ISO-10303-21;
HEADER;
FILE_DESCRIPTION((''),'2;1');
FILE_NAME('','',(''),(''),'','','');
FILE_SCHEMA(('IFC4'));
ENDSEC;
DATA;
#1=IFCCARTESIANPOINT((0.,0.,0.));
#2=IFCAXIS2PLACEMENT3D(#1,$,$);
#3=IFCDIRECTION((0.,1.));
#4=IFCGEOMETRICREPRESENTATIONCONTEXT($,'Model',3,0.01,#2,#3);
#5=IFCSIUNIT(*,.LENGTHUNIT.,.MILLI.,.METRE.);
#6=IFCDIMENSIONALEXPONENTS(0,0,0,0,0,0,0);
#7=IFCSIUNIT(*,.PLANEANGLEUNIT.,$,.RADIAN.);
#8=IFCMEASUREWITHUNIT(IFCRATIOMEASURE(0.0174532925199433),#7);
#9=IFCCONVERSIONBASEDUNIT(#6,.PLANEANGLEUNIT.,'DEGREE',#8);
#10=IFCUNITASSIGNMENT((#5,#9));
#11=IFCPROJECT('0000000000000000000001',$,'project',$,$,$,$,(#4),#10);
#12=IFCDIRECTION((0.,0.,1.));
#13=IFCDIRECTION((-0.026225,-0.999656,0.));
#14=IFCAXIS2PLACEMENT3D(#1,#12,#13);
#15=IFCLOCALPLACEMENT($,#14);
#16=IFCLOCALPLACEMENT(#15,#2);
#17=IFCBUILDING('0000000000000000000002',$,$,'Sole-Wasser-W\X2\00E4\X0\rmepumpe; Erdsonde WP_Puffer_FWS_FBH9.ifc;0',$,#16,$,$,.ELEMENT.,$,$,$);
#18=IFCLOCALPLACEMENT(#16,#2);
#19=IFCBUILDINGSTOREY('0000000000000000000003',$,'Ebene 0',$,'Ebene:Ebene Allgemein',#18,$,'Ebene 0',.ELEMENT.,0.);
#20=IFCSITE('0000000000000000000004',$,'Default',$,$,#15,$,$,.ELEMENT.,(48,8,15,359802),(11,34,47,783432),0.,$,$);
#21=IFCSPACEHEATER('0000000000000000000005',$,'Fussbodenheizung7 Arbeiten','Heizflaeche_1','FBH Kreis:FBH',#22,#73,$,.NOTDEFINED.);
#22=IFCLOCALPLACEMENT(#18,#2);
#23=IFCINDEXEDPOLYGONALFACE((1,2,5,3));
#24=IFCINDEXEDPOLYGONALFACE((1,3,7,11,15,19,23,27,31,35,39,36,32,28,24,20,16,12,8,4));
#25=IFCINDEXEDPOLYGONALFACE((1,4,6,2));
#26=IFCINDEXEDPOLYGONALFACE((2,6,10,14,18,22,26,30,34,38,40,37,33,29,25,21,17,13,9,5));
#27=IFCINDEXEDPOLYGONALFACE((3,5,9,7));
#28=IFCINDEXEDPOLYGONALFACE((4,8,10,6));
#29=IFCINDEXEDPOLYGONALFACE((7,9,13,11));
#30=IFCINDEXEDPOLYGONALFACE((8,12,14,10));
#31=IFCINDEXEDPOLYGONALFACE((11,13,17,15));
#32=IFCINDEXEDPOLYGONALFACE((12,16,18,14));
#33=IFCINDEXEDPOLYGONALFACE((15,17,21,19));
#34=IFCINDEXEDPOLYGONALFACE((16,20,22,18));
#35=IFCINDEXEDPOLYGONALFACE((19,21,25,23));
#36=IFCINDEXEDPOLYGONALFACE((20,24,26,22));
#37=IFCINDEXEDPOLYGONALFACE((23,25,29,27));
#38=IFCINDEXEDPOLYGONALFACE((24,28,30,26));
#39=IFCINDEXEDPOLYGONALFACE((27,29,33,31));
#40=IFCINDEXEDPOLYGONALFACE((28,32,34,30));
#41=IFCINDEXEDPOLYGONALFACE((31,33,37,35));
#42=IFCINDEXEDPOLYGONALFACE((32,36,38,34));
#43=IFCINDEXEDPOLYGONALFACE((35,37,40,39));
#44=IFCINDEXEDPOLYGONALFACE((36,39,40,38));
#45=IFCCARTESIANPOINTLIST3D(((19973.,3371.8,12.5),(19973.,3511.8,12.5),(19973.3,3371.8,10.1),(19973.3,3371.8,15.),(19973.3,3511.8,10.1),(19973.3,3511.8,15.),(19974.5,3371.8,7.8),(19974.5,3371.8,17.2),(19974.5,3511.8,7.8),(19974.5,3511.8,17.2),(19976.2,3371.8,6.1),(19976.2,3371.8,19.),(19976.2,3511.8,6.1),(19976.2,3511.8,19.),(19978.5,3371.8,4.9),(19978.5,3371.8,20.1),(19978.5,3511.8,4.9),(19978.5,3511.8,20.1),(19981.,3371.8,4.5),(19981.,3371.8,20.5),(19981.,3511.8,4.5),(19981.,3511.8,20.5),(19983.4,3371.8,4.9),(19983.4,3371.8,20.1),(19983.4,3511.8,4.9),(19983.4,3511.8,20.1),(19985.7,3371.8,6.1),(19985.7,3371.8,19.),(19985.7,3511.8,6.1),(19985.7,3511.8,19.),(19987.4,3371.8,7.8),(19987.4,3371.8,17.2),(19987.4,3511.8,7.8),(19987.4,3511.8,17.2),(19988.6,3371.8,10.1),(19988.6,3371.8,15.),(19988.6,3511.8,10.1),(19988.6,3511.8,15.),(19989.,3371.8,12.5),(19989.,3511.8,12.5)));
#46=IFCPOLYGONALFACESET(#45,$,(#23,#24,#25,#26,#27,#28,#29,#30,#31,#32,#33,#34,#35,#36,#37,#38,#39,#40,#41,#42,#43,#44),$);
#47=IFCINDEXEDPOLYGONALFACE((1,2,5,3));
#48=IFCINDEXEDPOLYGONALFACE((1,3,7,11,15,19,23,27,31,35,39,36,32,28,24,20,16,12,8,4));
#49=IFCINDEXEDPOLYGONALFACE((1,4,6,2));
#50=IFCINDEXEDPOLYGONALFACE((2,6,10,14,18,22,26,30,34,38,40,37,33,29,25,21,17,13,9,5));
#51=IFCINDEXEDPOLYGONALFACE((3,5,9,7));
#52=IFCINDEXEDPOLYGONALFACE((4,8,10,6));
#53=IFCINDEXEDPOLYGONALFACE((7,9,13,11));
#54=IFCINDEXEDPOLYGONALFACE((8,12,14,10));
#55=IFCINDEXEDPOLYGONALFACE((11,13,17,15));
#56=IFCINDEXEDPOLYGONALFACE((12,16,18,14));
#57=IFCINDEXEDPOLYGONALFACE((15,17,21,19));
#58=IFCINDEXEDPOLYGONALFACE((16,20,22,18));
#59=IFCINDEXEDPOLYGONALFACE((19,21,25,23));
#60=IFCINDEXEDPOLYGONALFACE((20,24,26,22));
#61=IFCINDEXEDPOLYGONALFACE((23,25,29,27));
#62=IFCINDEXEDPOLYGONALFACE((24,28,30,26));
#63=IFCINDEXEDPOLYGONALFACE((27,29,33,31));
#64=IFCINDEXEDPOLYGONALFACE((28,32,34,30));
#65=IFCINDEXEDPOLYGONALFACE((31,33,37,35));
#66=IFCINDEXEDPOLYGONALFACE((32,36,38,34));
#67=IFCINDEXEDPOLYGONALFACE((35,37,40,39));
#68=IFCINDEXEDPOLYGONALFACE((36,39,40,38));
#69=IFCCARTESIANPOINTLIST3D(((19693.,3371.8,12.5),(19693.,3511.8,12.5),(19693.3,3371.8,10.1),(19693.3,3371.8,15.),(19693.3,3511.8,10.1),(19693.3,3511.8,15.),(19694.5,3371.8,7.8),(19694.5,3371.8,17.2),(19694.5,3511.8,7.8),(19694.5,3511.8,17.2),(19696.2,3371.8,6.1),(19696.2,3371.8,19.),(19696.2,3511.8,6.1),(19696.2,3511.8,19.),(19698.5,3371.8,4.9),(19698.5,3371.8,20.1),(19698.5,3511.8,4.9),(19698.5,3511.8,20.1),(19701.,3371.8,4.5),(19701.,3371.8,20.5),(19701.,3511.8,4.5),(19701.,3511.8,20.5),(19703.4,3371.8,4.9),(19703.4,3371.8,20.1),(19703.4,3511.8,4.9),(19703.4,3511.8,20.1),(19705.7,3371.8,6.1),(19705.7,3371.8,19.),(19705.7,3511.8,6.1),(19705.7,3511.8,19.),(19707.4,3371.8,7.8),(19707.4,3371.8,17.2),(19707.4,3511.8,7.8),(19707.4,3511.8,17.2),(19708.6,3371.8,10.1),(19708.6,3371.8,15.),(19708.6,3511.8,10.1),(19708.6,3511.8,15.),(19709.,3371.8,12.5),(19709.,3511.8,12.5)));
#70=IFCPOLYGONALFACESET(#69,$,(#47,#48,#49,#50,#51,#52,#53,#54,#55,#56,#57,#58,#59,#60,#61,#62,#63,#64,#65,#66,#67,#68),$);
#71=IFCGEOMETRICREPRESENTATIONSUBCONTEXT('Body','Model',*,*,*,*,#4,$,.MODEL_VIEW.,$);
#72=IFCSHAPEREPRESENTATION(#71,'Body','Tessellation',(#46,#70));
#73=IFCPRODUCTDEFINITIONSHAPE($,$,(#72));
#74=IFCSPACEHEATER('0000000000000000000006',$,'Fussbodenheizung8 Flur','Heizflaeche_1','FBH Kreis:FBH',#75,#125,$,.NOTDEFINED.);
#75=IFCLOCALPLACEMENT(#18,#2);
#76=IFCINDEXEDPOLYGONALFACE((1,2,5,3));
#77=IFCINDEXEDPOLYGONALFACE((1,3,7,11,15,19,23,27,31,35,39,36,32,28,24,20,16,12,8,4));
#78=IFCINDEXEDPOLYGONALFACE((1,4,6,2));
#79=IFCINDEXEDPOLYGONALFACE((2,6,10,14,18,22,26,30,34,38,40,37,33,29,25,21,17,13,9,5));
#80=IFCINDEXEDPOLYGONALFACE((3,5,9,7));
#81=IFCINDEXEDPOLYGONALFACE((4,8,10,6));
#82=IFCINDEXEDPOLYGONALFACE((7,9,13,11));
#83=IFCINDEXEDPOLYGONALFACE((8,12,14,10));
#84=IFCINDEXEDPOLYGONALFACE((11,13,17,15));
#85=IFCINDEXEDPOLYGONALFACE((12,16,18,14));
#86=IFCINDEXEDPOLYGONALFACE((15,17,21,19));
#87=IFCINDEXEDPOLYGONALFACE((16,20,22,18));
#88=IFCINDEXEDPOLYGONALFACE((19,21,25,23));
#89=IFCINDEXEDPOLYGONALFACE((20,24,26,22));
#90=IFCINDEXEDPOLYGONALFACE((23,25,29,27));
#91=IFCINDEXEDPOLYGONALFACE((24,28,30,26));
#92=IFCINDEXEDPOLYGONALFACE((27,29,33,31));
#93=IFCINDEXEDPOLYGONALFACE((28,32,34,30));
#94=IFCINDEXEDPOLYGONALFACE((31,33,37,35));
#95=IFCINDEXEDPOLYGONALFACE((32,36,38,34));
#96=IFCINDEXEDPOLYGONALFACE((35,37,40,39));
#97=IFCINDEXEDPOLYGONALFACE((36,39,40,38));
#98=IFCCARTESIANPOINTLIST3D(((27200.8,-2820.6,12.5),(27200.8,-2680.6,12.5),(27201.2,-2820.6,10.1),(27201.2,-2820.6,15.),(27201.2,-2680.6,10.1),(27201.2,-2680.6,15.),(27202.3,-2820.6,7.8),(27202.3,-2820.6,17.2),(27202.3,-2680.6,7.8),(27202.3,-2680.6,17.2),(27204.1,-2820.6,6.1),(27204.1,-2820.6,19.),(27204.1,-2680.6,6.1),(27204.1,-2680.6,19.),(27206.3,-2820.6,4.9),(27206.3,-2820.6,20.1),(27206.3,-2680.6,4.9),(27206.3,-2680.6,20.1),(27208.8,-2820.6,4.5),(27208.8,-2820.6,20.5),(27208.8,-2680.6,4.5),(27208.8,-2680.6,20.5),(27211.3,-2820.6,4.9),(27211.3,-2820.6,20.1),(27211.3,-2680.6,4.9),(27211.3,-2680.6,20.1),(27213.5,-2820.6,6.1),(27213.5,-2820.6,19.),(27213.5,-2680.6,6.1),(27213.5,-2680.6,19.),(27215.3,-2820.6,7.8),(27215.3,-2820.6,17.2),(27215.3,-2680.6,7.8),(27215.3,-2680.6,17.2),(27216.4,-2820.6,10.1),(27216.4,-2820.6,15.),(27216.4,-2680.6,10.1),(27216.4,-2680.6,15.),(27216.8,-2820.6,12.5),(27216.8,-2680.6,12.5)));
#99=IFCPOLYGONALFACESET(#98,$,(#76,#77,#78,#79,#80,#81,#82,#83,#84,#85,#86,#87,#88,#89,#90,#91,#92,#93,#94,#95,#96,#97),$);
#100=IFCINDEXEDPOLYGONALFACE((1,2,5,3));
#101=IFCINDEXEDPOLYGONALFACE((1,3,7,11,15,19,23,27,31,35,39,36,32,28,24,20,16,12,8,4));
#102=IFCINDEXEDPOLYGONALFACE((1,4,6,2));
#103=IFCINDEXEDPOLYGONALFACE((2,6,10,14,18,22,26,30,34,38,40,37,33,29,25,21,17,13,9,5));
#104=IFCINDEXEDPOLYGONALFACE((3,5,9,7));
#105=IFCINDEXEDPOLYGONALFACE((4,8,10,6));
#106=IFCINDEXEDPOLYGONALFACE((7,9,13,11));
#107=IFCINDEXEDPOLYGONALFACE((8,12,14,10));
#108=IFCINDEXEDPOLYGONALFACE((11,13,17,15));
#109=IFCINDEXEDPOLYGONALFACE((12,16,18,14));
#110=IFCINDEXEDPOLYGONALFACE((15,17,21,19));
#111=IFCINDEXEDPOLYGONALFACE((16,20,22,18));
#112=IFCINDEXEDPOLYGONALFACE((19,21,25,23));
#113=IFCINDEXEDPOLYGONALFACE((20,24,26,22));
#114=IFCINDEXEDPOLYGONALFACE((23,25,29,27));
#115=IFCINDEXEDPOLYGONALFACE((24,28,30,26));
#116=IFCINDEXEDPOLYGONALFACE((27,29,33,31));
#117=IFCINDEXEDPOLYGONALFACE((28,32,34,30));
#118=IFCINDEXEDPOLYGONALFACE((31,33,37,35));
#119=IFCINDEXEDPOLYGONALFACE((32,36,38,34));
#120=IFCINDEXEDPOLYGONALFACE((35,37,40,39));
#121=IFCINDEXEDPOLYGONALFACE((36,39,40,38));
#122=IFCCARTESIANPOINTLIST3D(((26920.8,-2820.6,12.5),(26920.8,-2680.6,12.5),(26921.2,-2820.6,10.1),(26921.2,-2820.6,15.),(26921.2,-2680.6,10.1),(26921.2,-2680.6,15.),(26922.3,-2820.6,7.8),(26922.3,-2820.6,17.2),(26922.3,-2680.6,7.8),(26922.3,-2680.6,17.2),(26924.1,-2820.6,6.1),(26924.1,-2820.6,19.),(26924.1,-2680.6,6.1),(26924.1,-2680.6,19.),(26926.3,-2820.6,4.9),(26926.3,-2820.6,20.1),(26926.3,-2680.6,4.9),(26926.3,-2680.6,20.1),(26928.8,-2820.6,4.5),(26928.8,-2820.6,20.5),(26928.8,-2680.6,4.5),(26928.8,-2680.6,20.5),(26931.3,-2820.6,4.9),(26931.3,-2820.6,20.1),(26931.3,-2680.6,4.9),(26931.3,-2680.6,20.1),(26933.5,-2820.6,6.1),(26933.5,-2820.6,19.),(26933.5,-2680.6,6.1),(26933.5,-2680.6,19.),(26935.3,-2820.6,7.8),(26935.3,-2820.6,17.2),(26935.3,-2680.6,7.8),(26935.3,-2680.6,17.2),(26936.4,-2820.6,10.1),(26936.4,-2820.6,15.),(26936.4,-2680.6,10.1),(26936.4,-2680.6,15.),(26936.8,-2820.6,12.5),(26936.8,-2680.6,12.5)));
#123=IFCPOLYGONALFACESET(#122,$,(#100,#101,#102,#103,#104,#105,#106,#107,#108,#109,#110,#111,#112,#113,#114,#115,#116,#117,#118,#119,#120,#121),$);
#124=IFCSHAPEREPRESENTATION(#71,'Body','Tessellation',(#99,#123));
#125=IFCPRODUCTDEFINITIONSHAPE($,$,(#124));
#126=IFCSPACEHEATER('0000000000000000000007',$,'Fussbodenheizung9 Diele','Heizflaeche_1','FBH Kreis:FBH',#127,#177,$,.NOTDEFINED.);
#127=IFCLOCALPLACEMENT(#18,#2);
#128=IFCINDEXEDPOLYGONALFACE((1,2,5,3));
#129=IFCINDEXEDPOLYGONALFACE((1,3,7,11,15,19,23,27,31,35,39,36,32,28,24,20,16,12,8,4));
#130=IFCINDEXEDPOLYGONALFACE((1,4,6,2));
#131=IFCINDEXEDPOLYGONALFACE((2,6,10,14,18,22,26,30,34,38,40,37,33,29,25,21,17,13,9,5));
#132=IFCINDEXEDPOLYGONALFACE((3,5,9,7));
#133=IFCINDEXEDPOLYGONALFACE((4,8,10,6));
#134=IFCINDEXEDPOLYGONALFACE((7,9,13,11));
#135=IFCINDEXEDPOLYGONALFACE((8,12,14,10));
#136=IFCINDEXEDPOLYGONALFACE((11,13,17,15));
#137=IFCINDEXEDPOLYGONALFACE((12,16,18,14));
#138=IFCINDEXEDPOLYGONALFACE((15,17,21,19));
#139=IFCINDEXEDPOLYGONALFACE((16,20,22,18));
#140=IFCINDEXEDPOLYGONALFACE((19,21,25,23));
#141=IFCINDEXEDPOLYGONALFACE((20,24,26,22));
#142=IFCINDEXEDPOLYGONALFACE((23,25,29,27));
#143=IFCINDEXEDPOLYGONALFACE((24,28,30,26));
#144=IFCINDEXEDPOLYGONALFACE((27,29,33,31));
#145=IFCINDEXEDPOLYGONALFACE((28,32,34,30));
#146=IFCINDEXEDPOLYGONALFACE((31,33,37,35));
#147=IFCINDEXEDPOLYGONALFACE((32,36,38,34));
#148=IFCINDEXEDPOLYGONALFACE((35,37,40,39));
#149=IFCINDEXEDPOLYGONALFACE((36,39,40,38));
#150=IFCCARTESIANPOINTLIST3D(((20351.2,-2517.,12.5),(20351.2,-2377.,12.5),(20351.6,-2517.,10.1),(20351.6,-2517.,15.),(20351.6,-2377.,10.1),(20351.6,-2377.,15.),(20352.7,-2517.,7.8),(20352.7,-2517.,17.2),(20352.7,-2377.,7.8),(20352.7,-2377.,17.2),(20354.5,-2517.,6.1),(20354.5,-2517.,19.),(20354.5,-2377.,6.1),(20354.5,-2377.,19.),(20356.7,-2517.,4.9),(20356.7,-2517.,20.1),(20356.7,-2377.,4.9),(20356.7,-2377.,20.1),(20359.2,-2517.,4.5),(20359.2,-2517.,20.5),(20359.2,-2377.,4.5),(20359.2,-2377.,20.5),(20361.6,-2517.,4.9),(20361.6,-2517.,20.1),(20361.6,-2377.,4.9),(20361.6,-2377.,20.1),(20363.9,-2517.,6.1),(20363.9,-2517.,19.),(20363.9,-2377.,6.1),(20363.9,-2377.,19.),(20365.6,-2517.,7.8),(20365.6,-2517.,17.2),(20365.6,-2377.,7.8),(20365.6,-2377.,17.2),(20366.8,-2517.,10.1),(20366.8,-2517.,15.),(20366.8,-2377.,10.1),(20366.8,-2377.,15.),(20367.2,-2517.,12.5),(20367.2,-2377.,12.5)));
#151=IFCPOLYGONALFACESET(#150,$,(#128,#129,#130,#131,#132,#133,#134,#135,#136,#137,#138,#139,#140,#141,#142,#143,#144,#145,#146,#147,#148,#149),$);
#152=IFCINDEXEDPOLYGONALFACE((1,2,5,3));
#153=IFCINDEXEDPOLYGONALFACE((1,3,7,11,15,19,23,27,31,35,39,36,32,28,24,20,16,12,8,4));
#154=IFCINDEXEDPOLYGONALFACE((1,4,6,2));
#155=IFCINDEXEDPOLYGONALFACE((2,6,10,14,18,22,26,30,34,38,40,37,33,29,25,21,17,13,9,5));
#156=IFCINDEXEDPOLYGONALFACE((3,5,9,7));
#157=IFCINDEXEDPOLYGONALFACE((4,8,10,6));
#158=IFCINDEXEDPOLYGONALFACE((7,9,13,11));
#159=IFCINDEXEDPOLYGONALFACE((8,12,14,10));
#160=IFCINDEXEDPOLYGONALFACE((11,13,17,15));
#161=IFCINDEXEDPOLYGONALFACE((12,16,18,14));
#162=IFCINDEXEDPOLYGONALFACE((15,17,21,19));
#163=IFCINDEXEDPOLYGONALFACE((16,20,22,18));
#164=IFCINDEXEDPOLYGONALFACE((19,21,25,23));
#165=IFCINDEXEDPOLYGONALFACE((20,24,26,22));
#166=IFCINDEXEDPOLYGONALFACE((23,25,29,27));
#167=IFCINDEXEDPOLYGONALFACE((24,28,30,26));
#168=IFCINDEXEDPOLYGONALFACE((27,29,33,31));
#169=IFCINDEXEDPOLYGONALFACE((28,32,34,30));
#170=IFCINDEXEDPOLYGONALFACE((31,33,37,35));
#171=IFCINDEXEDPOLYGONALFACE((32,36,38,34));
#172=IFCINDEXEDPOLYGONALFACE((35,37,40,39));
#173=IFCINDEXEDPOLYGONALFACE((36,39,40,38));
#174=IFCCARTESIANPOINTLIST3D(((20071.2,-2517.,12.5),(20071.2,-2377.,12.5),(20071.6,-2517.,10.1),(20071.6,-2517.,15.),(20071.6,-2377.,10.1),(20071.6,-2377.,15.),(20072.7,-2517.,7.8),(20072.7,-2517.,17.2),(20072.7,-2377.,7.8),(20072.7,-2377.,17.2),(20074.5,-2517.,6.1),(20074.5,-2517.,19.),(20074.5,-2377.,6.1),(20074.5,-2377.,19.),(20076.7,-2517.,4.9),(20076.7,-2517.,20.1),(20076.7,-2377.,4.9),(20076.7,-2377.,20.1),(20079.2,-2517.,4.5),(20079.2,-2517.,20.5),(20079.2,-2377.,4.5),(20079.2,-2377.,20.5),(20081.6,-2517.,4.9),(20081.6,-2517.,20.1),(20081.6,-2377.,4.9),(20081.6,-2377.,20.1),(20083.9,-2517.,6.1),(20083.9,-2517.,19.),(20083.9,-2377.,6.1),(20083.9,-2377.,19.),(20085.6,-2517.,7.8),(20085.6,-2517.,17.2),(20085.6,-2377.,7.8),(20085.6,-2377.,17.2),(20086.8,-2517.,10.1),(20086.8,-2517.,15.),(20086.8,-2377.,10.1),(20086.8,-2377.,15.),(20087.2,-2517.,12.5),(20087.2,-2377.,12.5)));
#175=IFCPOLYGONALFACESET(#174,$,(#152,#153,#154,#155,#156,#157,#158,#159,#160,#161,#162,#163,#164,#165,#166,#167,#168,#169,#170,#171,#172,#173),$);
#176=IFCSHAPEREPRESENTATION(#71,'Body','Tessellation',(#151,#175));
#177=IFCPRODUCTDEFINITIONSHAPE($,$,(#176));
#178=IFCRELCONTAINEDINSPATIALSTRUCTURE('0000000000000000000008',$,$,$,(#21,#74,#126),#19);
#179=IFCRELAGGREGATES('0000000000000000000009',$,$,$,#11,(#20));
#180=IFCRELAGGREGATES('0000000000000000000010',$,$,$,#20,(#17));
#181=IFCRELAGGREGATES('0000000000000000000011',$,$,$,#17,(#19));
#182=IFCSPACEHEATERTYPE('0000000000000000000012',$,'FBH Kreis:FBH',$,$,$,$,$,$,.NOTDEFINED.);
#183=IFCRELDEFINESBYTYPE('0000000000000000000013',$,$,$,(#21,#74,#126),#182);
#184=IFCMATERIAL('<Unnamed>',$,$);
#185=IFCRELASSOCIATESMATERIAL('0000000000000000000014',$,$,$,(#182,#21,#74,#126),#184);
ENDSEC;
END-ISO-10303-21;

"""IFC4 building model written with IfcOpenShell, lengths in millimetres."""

from ifc_helpers import new_model, entity, si_unit, converted_unit, direction, frame, origin, place, context, subcontext, project, spatial, indexed_curve, outline, extrude, source, transform, mapped, material, type_object, type_shapes, element, save


model = new_model("IFC4")

# Units and contexts
model_context = context("Model", 3, precision=0.01, world=origin(), true_north=direction((0.0, 1.0)))
body_context = subcontext(model_context, "Body", "Model", "MODEL_VIEW")
ifc_project = project(units=[si_unit("LENGTHUNIT", "METRE", prefix="MILLI"), converted_unit("PLANEANGLEUNIT", "DEGREE", entity("IfcRatioMeasure", 0.0174532925199433), si_unit("PLANEANGLEUNIT", "RADIAN"), dimensions=[0, 0, 0, 0, 0, 0, 0])], contexts=[model_context])

# Site, building, storey
site_placement = place(None, frame((0.0, 0.0, 0.0), z_axis=(0.0, 0.0, 1.0), x_axis=(-0.026225, -0.999656, 0.0)))
site = spatial("IfcSite", under=ifc_project, at=site_placement, Name="Default", CompositionType="ELEMENT", RefLatitude=(48, 8, 15, 359802), RefLongitude=(11, 34, 47, 783432), RefElevation=0.0)
building_placement = place(site_placement, origin())
building = spatial("IfcBuilding", under=site, at=building_placement, Description="Sole-Wasser-Wärmepumpe; Erdsonde WP_Puffer_FWS_FBH9.ifc;0", CompositionType="ELEMENT")
storey_placement = place(building_placement, origin())
storey = spatial("IfcBuildingStorey", under=building, at=storey_placement, Name="Ebene 0", ObjectType="Ebene:Ebene Allgemein", LongName="Ebene 0", CompositionType="ELEMENT", Elevation=0.0)

# Space heaters
ifc_material = material(Name="<Unnamed>")
space_heater_type = type_object("IfcSpaceHeaterType", Name="FBH Kreis:FBH", PredefinedType="NOTDEFINED", material=ifc_material)
shared_shape = source(origin(), body_context, "Body", "SweptSolid", [
    extrude(outline(indexed_curve([(8.0, 0.0), (7.6, 2.5), (6.5, 4.7), (4.7, 6.5), (2.5, 7.6), (0.0, 8.0), (-2.5, 7.6), (-4.7, 6.5), (-6.5, 4.7), (-7.6, 2.5), (-8.0, 0.0), (-7.6, -2.5), (-6.5, -4.7), (-4.7, -6.5), (-2.5, -7.6), (0.0, -8.0), (2.5, -7.6), (4.7, -6.5), (6.5, -4.7), (7.6, -2.5), (8.0, 0.0)], self_intersect=False)), frame((140.0, -1621.8, -83.0), z_axis=(0.0, 1.0, 0.0), x_axis=(1.0, 0.0, 0.0)), (0.0, 0.0, 1.0), 140.0),
    extrude(outline(indexed_curve([(8.0, 0.0), (7.6, 2.5), (6.5, 4.7), (4.7, 6.5), (2.5, 7.6), (0.0, 8.0), (-2.5, 7.6), (-4.7, 6.5), (-6.5, 4.7), (-7.6, 2.5), (-8.0, 0.0), (-7.6, -2.5), (-6.5, -4.7), (-4.7, -6.5), (-2.5, -7.6), (0.0, -8.0), (2.5, -7.6), (4.7, -6.5), (6.5, -4.7), (7.6, -2.5), (8.0, 0.0)], self_intersect=False)), frame((-140.0, -1621.8, -83.0), z_axis=(0.0, 1.0, 0.0), x_axis=(1.0, 0.0, 0.0)), (0.0, 0.0, 1.0), 140.0),
])
type_shapes(space_heater_type, [shared_shape])
for number, where, name in (
    (1, (19841.0, 4993.5, 95.5), "Fussbodenheizung7 Arbeiten"),
    (2, (27068.8, -1198.9, 95.5), "Fussbodenheizung8 Flur"),
    (3, (20219.2, -895.2, 95.5), "Fussbodenheizung9 Diele"),
):
    element("IfcSpaceHeater", number, at=place(storey_placement, frame(where)), inside=storey, type_object=space_heater_type, material=ifc_material, Name=name, Description="Heizflaeche_1", ObjectType="FBH Kreis:FBH", PredefinedType="NOTDEFINED", context=body_context, shape_type="MappedRepresentation", body=[
        mapped(shared_shape, transform((0.0, 0.0, 0.0), scale=1.0)),
    ])

save(model, "model.ifc")
